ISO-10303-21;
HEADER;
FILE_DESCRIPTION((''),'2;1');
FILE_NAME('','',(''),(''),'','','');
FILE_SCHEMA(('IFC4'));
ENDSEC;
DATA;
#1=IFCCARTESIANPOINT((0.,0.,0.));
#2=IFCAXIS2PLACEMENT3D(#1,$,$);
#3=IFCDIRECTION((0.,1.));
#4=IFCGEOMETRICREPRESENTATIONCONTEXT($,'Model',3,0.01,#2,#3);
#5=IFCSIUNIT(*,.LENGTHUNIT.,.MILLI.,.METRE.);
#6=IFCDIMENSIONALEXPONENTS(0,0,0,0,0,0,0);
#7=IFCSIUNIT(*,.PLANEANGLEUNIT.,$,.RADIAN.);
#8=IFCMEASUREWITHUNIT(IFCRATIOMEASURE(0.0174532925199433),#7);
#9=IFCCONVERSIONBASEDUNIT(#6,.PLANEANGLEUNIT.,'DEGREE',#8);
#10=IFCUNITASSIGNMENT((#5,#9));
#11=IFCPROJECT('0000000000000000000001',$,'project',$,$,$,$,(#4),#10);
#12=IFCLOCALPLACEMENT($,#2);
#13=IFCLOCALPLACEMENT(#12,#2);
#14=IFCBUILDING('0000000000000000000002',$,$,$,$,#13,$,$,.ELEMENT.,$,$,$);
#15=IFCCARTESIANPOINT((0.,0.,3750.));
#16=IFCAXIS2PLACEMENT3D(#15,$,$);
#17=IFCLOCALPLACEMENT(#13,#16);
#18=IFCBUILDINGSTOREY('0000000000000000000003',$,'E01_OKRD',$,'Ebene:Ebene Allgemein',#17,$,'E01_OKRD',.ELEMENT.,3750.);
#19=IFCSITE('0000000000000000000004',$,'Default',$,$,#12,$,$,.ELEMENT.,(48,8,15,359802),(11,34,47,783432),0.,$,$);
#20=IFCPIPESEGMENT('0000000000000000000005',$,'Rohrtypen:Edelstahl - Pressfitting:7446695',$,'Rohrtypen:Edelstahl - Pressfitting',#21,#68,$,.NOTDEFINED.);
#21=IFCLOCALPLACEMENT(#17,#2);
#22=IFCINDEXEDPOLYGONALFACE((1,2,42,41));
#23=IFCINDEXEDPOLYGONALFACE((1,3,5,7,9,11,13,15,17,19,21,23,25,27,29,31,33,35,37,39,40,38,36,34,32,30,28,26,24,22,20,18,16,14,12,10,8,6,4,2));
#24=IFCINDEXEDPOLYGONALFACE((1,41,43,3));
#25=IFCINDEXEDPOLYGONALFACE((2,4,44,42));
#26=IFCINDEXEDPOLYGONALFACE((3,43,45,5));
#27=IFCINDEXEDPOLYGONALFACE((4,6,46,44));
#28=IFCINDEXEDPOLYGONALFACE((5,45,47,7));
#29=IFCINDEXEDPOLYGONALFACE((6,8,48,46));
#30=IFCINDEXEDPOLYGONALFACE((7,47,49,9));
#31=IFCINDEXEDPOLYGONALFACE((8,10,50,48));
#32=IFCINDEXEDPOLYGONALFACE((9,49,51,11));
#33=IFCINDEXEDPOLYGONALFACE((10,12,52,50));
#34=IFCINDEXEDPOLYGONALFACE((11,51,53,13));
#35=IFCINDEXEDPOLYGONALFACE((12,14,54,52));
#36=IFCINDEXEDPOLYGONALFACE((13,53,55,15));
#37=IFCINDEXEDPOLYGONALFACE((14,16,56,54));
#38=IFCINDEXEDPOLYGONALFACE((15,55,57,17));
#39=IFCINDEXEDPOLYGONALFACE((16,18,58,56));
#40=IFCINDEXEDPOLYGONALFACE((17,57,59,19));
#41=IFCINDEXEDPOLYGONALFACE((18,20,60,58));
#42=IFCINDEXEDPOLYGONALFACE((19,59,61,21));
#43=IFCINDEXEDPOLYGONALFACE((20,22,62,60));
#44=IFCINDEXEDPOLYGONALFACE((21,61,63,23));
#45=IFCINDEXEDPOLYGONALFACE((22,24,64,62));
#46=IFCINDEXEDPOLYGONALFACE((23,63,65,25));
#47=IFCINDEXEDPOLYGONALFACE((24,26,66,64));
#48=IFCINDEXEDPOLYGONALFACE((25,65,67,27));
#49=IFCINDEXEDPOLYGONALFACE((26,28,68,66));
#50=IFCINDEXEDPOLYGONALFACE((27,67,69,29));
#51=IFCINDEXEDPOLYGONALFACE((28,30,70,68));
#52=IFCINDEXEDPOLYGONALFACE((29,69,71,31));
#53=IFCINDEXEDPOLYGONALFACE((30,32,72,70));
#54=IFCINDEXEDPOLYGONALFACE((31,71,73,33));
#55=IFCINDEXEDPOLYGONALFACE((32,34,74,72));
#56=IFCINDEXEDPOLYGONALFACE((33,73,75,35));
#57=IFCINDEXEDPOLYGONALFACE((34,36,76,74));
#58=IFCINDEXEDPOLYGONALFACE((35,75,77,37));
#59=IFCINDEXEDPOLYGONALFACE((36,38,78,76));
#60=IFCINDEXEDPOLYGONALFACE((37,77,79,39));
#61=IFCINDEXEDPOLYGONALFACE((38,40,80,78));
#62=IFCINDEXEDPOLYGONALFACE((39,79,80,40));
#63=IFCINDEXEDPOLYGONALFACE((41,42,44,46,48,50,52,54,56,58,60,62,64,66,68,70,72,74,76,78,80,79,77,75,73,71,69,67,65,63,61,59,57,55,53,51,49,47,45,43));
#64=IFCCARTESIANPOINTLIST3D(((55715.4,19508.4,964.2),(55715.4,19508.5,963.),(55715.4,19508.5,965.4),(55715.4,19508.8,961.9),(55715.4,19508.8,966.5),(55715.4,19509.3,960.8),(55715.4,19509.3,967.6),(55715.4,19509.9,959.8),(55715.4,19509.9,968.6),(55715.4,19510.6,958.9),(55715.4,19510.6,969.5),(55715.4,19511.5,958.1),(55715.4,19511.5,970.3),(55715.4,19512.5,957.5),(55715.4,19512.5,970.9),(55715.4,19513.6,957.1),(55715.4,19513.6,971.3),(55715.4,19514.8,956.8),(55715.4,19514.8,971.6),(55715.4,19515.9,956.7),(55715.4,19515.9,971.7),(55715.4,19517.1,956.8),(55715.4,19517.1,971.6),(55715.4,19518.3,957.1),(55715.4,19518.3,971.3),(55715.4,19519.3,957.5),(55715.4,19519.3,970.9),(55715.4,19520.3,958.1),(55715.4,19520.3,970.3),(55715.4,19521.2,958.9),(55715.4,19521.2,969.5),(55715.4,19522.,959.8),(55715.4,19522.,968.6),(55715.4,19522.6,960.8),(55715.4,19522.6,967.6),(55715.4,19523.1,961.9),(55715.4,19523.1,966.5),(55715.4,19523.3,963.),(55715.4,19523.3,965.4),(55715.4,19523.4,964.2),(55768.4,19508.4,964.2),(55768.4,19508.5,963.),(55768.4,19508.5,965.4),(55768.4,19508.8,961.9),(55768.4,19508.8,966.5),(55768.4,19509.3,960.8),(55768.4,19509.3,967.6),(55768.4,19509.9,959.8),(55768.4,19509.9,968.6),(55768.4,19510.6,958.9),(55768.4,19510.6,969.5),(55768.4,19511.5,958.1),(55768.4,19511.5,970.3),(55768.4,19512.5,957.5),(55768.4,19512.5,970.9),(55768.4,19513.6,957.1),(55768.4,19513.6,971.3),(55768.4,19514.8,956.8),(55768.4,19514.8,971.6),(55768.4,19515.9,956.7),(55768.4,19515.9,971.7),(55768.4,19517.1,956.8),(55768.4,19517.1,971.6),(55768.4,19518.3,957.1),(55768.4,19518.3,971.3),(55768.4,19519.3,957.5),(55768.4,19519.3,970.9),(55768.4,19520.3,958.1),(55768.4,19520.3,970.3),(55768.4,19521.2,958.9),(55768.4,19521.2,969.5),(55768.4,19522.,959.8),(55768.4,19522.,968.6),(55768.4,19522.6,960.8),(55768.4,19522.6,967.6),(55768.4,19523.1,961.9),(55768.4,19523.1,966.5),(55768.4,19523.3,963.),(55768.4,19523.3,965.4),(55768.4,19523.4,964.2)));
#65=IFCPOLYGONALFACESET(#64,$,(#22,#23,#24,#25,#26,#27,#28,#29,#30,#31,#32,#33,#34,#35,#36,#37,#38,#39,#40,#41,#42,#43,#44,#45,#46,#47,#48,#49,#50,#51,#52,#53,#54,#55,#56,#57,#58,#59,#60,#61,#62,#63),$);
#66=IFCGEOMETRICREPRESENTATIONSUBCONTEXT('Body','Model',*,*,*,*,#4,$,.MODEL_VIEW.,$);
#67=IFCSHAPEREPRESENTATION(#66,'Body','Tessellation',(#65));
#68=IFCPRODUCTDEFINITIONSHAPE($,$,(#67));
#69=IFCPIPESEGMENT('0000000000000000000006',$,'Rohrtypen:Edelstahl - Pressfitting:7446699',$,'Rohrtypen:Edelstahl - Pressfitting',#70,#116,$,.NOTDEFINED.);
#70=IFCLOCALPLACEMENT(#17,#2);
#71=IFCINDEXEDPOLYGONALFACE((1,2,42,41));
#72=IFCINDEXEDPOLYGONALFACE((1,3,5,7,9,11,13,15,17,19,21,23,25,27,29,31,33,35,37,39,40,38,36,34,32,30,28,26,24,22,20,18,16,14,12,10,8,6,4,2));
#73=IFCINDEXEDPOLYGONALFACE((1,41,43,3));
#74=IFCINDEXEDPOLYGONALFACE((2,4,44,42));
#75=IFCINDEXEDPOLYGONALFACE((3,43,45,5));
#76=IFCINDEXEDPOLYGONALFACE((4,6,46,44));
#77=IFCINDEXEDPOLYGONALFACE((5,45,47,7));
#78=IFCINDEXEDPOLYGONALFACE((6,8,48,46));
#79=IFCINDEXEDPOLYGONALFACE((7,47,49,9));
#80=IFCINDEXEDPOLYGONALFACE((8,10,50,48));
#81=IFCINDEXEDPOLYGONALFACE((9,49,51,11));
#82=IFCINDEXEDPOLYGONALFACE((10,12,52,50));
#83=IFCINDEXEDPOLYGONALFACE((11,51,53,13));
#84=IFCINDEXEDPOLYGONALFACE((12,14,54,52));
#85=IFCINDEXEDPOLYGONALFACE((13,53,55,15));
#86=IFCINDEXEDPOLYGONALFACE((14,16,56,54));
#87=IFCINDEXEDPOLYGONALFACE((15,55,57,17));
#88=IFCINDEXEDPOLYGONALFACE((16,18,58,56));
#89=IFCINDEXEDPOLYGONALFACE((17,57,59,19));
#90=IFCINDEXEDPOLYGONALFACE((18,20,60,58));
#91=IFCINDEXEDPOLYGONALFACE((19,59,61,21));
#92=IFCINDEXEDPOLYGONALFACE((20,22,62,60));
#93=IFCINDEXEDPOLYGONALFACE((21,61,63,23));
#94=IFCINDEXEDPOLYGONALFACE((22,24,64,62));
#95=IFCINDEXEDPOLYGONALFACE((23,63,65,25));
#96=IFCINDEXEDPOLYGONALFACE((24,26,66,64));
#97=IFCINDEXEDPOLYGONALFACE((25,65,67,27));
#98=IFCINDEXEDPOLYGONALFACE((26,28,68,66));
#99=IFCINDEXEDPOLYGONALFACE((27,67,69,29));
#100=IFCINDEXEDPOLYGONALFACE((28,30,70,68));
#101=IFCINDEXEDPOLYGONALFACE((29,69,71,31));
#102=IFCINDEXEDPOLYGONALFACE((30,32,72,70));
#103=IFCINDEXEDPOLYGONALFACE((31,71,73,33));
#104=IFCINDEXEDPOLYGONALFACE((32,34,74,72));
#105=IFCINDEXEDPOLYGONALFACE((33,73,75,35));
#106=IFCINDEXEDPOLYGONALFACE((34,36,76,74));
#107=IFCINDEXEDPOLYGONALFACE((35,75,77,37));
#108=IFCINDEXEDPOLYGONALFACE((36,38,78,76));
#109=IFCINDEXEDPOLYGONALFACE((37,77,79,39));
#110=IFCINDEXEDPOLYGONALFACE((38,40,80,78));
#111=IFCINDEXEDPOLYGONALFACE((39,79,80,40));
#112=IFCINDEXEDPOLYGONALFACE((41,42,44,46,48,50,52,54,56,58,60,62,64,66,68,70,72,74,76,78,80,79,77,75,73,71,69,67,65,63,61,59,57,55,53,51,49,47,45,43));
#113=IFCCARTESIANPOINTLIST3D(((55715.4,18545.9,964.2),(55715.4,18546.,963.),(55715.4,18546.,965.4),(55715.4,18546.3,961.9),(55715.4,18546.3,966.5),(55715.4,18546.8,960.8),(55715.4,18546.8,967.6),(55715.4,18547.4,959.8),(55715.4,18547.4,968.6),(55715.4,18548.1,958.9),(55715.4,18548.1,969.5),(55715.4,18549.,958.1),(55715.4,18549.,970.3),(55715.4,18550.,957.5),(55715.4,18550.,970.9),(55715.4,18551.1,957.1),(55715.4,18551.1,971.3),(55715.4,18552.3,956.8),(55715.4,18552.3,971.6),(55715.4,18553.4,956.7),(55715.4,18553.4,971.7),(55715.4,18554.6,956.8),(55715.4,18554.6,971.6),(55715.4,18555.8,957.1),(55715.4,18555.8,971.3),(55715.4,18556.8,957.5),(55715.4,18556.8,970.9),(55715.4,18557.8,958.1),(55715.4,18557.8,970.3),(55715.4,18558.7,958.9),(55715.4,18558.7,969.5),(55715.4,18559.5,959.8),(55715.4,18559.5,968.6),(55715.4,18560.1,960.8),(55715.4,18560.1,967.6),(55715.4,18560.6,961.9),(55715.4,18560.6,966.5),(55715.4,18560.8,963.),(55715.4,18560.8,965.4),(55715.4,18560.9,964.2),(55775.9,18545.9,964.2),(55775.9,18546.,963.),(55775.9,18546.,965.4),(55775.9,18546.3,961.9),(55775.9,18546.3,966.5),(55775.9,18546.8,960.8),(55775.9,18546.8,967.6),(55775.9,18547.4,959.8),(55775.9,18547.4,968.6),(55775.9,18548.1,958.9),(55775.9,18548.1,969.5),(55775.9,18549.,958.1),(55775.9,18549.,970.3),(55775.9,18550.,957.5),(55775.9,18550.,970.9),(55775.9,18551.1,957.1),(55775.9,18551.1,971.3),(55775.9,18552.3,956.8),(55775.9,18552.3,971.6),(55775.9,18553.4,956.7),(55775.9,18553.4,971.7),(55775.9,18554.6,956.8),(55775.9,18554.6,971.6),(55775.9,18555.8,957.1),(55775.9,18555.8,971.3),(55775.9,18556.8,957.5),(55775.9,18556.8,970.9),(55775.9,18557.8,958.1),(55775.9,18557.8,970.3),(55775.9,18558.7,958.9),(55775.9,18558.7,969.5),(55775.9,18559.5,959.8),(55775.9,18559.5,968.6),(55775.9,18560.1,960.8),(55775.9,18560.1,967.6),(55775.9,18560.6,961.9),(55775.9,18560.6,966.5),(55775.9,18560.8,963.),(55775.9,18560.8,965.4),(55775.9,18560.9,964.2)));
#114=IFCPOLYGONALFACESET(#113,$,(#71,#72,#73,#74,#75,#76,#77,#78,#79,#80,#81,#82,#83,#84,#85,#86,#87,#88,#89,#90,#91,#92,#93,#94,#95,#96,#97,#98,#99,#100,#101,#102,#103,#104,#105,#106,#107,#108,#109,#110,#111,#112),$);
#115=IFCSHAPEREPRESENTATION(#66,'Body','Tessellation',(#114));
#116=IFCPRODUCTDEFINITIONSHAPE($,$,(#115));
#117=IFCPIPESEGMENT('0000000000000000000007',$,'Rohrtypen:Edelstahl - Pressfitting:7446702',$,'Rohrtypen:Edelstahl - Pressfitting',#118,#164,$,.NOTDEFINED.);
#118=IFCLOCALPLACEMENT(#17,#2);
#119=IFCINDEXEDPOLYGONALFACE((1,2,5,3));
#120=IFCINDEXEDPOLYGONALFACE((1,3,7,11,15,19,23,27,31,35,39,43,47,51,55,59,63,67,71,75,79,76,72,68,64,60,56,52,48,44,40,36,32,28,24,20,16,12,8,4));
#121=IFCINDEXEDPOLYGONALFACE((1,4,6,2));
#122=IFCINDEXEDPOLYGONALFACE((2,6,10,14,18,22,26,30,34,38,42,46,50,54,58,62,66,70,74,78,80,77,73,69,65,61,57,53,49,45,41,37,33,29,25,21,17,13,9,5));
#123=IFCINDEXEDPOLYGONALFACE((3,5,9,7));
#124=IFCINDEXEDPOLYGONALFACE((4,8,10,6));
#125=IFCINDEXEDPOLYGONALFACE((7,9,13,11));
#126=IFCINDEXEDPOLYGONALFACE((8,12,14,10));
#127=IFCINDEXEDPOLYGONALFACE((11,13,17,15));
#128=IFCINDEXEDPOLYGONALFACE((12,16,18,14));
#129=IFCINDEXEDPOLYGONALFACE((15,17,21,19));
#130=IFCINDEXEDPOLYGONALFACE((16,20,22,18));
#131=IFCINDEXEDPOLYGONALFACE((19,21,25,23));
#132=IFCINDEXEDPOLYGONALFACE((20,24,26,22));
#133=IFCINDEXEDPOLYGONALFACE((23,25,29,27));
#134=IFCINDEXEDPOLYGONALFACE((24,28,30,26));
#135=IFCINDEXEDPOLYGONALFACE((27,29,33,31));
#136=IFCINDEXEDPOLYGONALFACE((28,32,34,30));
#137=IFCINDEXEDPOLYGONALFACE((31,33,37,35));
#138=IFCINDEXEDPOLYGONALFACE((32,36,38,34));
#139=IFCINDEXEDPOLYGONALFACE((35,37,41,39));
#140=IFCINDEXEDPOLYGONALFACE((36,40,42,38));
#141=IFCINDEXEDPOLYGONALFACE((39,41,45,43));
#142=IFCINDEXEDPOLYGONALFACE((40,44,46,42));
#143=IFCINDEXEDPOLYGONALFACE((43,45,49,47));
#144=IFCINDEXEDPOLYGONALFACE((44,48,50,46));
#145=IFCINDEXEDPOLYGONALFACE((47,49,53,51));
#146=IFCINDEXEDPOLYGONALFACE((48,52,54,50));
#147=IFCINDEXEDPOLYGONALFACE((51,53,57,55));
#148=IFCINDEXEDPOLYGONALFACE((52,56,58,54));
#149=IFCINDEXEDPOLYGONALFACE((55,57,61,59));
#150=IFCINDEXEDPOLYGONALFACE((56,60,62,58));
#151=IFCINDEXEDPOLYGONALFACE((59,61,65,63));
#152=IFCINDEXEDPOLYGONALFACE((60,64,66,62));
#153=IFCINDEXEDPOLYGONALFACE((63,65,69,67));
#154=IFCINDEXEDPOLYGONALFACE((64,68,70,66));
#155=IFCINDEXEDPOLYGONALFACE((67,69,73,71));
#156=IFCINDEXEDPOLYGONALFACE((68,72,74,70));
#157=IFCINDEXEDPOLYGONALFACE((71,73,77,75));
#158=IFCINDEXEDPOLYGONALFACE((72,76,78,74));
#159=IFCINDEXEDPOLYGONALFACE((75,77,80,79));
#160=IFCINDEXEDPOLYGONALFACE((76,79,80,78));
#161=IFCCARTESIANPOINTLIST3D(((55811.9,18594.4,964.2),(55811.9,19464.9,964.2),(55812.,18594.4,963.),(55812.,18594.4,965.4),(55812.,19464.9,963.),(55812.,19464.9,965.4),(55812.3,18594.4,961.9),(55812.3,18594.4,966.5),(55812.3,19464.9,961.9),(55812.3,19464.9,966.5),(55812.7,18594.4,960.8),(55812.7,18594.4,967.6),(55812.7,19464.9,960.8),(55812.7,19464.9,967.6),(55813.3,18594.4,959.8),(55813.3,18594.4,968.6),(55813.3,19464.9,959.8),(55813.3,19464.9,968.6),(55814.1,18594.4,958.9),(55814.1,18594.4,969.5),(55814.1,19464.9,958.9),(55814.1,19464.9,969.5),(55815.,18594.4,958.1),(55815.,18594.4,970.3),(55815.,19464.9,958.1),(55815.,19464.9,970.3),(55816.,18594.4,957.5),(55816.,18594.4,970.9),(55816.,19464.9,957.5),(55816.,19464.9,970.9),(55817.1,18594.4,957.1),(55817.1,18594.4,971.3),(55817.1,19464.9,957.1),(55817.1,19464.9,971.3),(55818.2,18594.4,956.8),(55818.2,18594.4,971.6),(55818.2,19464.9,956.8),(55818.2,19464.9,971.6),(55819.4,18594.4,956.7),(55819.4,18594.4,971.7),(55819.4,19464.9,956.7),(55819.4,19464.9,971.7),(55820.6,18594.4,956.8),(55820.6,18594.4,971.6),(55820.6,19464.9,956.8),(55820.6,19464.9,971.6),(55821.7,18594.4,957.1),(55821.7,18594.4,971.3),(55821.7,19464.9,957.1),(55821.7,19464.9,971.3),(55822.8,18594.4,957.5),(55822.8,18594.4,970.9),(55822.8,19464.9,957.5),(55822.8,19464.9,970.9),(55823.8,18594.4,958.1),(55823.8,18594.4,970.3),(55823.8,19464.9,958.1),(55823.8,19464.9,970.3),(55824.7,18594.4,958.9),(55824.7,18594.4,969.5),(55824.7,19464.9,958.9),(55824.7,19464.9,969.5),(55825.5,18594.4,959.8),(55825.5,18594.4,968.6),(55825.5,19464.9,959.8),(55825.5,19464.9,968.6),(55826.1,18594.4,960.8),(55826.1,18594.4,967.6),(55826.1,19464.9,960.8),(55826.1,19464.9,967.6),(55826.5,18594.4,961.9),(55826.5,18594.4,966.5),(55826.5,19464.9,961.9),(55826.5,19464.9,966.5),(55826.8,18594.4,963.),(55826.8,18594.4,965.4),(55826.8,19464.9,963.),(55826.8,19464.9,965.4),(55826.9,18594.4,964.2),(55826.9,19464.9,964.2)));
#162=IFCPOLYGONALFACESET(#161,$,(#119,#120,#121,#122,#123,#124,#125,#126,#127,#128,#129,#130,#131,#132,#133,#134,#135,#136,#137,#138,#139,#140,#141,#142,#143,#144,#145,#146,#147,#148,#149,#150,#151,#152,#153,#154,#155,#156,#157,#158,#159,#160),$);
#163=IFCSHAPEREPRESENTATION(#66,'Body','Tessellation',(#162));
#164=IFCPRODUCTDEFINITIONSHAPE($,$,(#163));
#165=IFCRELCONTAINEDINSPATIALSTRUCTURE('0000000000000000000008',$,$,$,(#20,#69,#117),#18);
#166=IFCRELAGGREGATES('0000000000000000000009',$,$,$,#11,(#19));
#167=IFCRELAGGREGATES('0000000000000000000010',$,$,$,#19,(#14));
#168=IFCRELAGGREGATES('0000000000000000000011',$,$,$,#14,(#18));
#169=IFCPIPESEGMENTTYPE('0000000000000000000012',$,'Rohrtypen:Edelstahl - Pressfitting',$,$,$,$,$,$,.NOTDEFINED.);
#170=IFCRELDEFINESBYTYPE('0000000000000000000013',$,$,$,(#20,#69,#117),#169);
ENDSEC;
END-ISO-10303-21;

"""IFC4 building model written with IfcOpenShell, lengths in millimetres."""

from ifc_helpers import new_model, entity, si_unit, converted_unit, direction, frame, origin, place, context, subcontext, project, spatial, indexed_curve, outline, extrude, type_object, element, save


model = new_model("IFC4")

# Units and contexts
model_context = context("Model", 3, precision=0.01, world=origin(), true_north=direction((0.0, 1.0)))
body_context = subcontext(model_context, "Body", "Model", "MODEL_VIEW")
ifc_project = project(units=[si_unit("LENGTHUNIT", "METRE", prefix="MILLI"), converted_unit("PLANEANGLEUNIT", "DEGREE", entity("IfcRatioMeasure", 0.0174532925199433), si_unit("PLANEANGLEUNIT", "RADIAN"), dimensions=[0, 0, 0, 0, 0, 0, 0])], contexts=[model_context])

# Site, building, storey
site_placement = place(None, origin())
site = spatial("IfcSite", under=ifc_project, at=site_placement, Name="Default", CompositionType="ELEMENT", RefLatitude=(48, 8, 15, 359802), RefLongitude=(11, 34, 47, 783432), RefElevation=0.0)
building_placement = place(site_placement, origin())
building = spatial("IfcBuilding", under=site, at=building_placement, CompositionType="ELEMENT")
storey_placement = place(building_placement, frame((0.0, 0.0, 3750.0)))
storey = spatial("IfcBuildingStorey", under=building, at=storey_placement, Name="E01_OKRD", ObjectType="Ebene:Ebene Allgemein", LongName="E01_OKRD", CompositionType="ELEMENT", Elevation=3750.0)

# Pipe segments
pipe_segment_type_1 = type_object("IfcPipeSegmentType", Name="Rohrtypen:Edelstahl - Pressfitting", PredefinedType="NOTDEFINED")
pipe_segment_1_placement = place(storey_placement, origin())
element("IfcPipeSegment", 1, at=pipe_segment_1_placement, inside=storey, type_object=pipe_segment_type_1, Name="Rohrtypen:Edelstahl - Pressfitting:7446695", ObjectType="Rohrtypen:Edelstahl - Pressfitting", PredefinedType="NOTDEFINED", context=body_context, shape_type="SweptSolid", body=[
    extrude(outline(indexed_curve([(7.5, 0.0), (7.4, 1.2), (7.1, 2.3), (6.7, 3.4), (6.1, 4.4), (5.3, 5.3), (4.4, 6.1), (3.4, 6.7), (2.3, 7.1), (1.2, 7.4), (0.0, 7.5), (-1.2, 7.4), (-2.3, 7.1), (-3.4, 6.7), (-4.4, 6.1), (-5.3, 5.3), (-6.1, 4.4), (-6.7, 3.4), (-7.1, 2.3), (-7.4, 1.2), (-7.5, 0.0), (-7.4, -1.2), (-7.1, -2.3), (-6.7, -3.4), (-6.1, -4.4), (-5.3, -5.3), (-4.4, -6.1), (-3.4, -6.7), (-2.3, -7.1), (-1.2, -7.4), (0.0, -7.5), (1.2, -7.4), (2.3, -7.1), (3.4, -6.7), (4.4, -6.1), (5.3, -5.3), (6.1, -4.4), (6.7, -3.4), (7.1, -2.3), (7.4, -1.2), (7.5, 0.0)], self_intersect=False)), frame((55715.4, 19515.9, 964.2), z_axis=(1.0, 0.0, 0.0), x_axis=(0.0, -1.0, 0.0)), (0.0, 0.0, 1.0), 53.0),
])
pipe_segment_2_placement = place(storey_placement, origin())
element("IfcPipeSegment", 2, at=pipe_segment_2_placement, inside=storey, type_object=pipe_segment_type_1, Name="Rohrtypen:Edelstahl - Pressfitting:7446699", ObjectType="Rohrtypen:Edelstahl - Pressfitting", PredefinedType="NOTDEFINED", context=body_context, shape_type="SweptSolid", body=[
    extrude(outline(indexed_curve([(7.5, 0.0), (7.4, 1.2), (7.1, 2.3), (6.7, 3.4), (6.1, 4.4), (5.3, 5.3), (4.4, 6.1), (3.4, 6.7), (2.3, 7.1), (1.2, 7.4), (0.0, 7.5), (-1.2, 7.4), (-2.3, 7.1), (-3.4, 6.7), (-4.4, 6.1), (-5.3, 5.3), (-6.1, 4.4), (-6.7, 3.4), (-7.1, 2.3), (-7.4, 1.2), (-7.5, 0.0), (-7.4, -1.2), (-7.1, -2.3), (-6.7, -3.4), (-6.1, -4.4), (-5.3, -5.3), (-4.4, -6.1), (-3.4, -6.7), (-2.3, -7.1), (-1.2, -7.4), (0.0, -7.5), (1.2, -7.4), (2.3, -7.1), (3.4, -6.7), (4.4, -6.1), (5.3, -5.3), (6.1, -4.4), (6.7, -3.4), (7.1, -2.3), (7.4, -1.2), (7.5, 0.0)], self_intersect=False)), frame((55715.4, 18553.4, 964.2), z_axis=(1.0, 0.0, 0.0), x_axis=(0.0, 1.0, 0.0)), (0.0, 0.0, 1.0), 60.5),
])
pipe_segment_3_placement = place(storey_placement, origin())
element("IfcPipeSegment", 3, at=pipe_segment_3_placement, inside=storey, type_object=pipe_segment_type_1, Name="Rohrtypen:Edelstahl - Pressfitting:7446702", ObjectType="Rohrtypen:Edelstahl - Pressfitting", PredefinedType="NOTDEFINED", context=body_context, shape_type="SweptSolid", body=[
    extrude(outline(indexed_curve([(7.5, 0.0), (7.4, 1.2), (7.1, 2.3), (6.7, 3.4), (6.1, 4.4), (5.3, 5.3), (4.4, 6.1), (3.4, 6.7), (2.3, 7.1), (1.2, 7.4), (0.0, 7.5), (-1.2, 7.4), (-2.3, 7.1), (-3.4, 6.7), (-4.4, 6.1), (-5.3, 5.3), (-6.1, 4.4), (-6.7, 3.4), (-7.1, 2.3), (-7.4, 1.2), (-7.5, 0.0), (-7.4, -1.2), (-7.1, -2.3), (-6.7, -3.4), (-6.1, -4.4), (-5.3, -5.3), (-4.4, -6.1), (-3.4, -6.7), (-2.3, -7.1), (-1.2, -7.4), (0.0, -7.5), (1.2, -7.4), (2.3, -7.1), (3.4, -6.7), (4.4, -6.1), (5.3, -5.3), (6.1, -4.4), (6.7, -3.4), (7.1, -2.3), (7.4, -1.2), (7.5, 0.0)], self_intersect=False)), frame((55819.4, 18594.4, 964.2), z_axis=(0.0, 1.0, 0.0), x_axis=(-1.0, 0.0, 0.0)), (0.0, 0.0, 1.0), 870.5),
])

save(model, "model.ifc")
